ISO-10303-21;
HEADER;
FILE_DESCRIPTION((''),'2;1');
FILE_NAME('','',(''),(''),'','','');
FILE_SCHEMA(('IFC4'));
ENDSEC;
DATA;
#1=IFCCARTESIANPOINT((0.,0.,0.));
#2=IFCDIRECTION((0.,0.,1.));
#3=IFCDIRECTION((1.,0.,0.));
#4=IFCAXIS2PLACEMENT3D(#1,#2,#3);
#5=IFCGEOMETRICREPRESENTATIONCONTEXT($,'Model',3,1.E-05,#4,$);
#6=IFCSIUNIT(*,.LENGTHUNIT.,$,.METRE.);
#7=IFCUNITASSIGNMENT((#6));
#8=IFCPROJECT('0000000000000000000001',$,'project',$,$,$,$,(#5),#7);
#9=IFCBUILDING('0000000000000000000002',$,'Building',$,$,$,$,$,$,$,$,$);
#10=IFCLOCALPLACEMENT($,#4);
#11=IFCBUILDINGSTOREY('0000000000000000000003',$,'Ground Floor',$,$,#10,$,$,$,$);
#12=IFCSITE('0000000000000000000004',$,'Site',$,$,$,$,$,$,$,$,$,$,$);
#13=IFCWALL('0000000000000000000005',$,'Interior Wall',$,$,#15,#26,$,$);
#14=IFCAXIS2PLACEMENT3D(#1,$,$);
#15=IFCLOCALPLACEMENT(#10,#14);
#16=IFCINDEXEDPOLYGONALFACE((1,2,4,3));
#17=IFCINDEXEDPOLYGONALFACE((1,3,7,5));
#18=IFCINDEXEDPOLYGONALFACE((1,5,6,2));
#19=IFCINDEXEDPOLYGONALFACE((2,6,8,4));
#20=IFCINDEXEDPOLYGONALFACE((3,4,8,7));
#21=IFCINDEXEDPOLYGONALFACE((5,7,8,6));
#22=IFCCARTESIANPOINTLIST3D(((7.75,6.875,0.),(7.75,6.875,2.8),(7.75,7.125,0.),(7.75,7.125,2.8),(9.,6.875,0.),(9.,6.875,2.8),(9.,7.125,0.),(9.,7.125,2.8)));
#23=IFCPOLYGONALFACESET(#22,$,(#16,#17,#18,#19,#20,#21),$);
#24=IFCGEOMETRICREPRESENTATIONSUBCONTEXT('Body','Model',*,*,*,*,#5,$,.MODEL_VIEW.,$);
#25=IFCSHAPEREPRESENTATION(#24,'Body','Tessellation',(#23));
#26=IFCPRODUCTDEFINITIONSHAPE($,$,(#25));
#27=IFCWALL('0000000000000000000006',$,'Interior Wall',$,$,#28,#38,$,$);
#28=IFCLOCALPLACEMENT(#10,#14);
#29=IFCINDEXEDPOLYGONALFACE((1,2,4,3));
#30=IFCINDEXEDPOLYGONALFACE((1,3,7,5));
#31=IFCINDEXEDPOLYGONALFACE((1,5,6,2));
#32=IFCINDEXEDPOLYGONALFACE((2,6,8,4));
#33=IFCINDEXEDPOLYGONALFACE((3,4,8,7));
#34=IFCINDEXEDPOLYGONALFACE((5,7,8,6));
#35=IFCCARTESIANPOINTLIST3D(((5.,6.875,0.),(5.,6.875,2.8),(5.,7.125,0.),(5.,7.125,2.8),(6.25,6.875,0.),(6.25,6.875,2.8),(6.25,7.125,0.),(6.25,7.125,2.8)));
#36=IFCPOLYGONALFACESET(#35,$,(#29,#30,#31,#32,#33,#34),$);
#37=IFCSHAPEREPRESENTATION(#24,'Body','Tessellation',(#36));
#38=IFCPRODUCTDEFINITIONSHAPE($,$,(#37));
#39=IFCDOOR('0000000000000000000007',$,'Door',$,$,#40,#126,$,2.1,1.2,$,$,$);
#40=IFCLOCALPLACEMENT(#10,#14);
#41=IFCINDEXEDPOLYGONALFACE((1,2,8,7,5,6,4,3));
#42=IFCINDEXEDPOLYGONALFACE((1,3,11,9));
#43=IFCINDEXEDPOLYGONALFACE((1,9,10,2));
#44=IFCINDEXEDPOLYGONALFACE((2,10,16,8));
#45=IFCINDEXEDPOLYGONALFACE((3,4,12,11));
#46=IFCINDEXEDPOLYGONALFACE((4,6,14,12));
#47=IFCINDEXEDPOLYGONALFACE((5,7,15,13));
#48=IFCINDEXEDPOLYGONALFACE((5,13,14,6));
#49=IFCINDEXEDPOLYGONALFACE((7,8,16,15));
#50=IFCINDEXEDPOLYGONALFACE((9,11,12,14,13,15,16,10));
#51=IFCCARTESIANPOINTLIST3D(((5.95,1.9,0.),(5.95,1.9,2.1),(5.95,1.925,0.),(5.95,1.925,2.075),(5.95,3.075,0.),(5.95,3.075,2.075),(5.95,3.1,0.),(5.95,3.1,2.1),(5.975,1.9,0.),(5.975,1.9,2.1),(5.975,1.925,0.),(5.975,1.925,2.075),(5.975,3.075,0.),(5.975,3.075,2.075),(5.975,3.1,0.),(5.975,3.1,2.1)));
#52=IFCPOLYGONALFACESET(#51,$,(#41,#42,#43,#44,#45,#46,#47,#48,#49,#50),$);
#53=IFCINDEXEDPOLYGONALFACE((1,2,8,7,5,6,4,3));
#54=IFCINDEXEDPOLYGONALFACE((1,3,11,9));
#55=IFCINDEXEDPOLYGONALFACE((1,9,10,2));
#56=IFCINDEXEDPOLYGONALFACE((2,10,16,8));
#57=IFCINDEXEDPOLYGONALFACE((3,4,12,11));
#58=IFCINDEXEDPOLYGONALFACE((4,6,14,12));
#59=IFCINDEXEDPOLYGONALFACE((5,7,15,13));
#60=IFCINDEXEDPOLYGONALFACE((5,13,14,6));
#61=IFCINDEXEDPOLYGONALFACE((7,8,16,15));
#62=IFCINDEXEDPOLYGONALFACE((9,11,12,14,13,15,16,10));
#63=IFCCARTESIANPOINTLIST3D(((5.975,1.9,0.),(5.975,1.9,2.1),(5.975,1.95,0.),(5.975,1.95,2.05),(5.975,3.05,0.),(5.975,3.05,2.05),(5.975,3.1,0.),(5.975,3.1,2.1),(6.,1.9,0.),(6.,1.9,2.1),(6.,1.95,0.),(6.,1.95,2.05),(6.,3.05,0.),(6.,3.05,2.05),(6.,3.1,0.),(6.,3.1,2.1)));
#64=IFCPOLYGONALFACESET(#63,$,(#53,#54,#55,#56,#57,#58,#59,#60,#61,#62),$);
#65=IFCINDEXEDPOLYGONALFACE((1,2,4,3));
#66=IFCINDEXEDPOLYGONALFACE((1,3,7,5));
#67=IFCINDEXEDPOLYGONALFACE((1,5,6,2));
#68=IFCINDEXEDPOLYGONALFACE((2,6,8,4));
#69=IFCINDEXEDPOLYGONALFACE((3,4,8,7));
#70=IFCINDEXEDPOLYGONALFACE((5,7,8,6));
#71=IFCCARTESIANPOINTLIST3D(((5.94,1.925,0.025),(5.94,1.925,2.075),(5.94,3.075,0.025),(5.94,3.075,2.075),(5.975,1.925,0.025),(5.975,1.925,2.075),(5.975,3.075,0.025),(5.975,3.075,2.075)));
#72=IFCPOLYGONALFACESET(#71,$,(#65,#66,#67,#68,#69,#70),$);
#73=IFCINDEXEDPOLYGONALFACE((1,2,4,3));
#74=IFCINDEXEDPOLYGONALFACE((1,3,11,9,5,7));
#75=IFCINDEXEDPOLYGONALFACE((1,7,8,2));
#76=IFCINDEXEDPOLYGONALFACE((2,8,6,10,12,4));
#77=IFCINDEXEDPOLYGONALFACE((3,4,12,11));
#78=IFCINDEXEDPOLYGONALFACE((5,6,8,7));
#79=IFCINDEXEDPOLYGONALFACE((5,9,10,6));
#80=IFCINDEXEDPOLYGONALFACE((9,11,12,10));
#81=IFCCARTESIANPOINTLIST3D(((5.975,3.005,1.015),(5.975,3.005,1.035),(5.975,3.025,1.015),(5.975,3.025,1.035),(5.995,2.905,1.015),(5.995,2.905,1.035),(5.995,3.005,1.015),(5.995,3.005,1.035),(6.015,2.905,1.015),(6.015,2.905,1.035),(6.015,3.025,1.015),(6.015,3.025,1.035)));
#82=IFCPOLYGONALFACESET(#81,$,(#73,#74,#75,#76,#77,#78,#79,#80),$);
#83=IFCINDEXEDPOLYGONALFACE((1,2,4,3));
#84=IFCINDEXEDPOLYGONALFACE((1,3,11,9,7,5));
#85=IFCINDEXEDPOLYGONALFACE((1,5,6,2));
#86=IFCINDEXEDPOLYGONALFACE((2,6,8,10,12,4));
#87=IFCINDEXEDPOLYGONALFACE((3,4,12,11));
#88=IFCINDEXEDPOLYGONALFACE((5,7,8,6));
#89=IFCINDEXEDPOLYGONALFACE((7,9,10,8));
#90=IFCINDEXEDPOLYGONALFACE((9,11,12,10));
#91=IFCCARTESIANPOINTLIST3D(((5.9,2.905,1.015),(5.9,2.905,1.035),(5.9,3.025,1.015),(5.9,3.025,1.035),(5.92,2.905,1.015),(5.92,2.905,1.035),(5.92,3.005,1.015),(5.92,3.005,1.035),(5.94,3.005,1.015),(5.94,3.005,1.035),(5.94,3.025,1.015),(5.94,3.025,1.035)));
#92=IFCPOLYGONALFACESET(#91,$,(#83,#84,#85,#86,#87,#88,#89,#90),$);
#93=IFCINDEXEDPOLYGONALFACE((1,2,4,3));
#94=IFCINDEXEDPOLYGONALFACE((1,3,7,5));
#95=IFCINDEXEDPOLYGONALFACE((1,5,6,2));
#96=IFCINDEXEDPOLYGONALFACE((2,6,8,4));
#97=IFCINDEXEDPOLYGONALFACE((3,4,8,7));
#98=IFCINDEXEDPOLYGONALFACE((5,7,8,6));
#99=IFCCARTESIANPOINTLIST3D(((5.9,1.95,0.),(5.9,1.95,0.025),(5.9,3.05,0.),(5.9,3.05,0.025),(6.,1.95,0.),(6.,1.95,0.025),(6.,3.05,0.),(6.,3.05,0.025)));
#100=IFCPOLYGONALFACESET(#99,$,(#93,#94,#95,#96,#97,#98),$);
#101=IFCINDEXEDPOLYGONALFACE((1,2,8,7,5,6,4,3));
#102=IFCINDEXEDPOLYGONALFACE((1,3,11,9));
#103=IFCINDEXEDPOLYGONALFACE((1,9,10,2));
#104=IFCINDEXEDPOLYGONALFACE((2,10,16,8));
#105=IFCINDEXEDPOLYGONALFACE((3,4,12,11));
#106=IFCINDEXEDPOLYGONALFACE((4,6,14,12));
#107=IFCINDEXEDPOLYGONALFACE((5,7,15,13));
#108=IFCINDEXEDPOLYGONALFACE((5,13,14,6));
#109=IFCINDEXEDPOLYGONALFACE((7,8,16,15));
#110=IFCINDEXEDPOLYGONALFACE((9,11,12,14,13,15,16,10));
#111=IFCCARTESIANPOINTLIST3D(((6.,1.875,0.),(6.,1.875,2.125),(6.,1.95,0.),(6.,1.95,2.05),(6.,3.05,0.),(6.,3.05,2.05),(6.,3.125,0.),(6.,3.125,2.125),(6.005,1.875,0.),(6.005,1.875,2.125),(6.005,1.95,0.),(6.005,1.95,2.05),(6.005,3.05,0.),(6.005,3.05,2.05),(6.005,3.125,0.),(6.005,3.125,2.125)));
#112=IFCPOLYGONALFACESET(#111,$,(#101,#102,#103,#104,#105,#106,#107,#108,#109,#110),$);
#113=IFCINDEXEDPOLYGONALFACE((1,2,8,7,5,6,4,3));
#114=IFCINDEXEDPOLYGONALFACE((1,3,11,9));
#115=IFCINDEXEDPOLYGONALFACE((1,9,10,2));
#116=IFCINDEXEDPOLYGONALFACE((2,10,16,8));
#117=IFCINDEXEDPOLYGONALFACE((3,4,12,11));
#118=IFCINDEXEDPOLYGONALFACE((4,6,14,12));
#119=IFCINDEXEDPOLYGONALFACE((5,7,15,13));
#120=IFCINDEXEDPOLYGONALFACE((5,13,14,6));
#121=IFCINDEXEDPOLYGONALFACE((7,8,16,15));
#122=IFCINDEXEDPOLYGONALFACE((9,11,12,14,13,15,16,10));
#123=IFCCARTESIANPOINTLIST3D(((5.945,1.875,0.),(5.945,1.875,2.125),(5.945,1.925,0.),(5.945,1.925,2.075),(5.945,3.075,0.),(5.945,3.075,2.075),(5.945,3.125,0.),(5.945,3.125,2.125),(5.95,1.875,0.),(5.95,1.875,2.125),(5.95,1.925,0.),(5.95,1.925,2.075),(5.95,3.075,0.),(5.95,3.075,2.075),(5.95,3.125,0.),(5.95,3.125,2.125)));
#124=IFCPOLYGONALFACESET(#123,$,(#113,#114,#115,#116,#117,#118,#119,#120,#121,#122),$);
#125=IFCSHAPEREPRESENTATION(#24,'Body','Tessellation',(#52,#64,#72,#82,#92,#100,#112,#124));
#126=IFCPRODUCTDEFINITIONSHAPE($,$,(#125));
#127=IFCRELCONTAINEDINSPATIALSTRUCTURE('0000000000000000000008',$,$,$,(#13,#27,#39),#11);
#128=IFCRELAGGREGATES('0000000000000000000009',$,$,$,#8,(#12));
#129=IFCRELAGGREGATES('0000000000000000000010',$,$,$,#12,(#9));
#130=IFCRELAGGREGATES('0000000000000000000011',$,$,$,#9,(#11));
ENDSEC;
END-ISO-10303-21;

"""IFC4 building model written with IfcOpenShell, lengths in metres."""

from ifc_helpers import new_model, si_unit, frame, origin_with_axes, place, context, subcontext, project, spatial, line, indexed_curve, outline, extrude, element, save


model = new_model("IFC4")

# Units and contexts
model_context = context("Model", 3, precision=1e-05, world=origin_with_axes())
body_context = subcontext(model_context, "Body", "Model", "MODEL_VIEW")
ifc_project = project(units=[si_unit("LENGTHUNIT", "METRE")], contexts=[model_context])

# Site, building, storey
site = spatial("IfcSite", under=ifc_project, Name="Site")
building = spatial("IfcBuilding", under=site, Name="Building")
storey_placement = place(None, origin_with_axes())
storey = spatial("IfcBuildingStorey", under=building, at=storey_placement, Name="Ground Floor")

# Walls
for number, where, z_axis, x_axis, name in (
    (1, (9.0, 7.0, 0.0), (0.0, 0.0, 1.0), (-1.0, 0.0, 0.0), "Interior Wall"),
    (2, (6.25, 7.0, 0.0), (0.0, 0.0, 1.0), (-1.0, 0.0, 0.0), "Interior Wall"),
):
    element("IfcWall", number, at=place(storey_placement, frame(where, z_axis=z_axis, x_axis=x_axis)), inside=storey, Name=name, context=body_context, shape_type="SweptSolid", body=[
        extrude(outline(indexed_curve([(0.0, 0.0), (0.0, 0.25), (1.25, 0.25), (1.25, 0.0), (0.0, 0.0)], self_intersect=False)), frame((0.0, -0.125, 0.0), z_axis=(0.0, 0.0, 1.0), x_axis=(1.0, 0.0, 0.0)), (0.0, 0.0, 1.0), 2.8),
    ])

# Door
door_1_placement = place(storey_placement, frame((6.0, 1.9, 0.0), z_axis=(0.0, 0.0, 1.0), x_axis=(0.0, 1.0, 0.0)))
element("IfcDoor", 3, at=door_1_placement, inside=storey, Name="Door", OverallHeight=2.1, OverallWidth=1.2, context=body_context, shape_type="SweptSolid", body=[
    extrude(outline(indexed_curve([(0.0, 0.0), (0.0, 2.1), (1.2, 2.1), (1.2, 0.0), (1.175, 0.0), (1.175, 2.075), (0.025, 2.075), (0.025, 0.0)], segments=[line(1, 2, 3, 4, 5, 6, 7, 8, 1)])), frame((0.0, 0.025, 0.0), z_axis=(0.0, -1.0, 0.0), x_axis=(1.0, 0.0, 0.0)), (0.0, 0.0, -1.0), 0.025),
    extrude(outline(indexed_curve([(0.0, 0.0), (0.0, 2.1), (1.2, 2.1), (1.2, 0.0), (1.15, 0.0), (1.15, 2.05), (0.05, 2.05), (0.05, 0.0)], segments=[line(1, 2, 3, 4, 5, 6, 7, 8, 1)])), frame((0.0, 0.0, 0.0), z_axis=(0.0, -1.0, 0.0), x_axis=(1.0, 0.0, 0.0)), (0.0, 0.0, -1.0), 0.025),
    extrude(outline(indexed_curve([(0.0, 0.0), (1.15, 0.0), (1.15, 0.035), (0.0, 0.035)], segments=[line(1, 2, 3, 4, 1)])), frame((0.025, 0.025, 0.025), z_axis=(0.0, 0.0, 1.0), x_axis=(1.0, 0.0, 0.0)), (0.0, 0.0, 1.0), 2.05),
    extrude(outline(indexed_curve([(0.0, 0.0), (0.0, -0.04), (-0.12, -0.04), (-0.12, -0.02), (-0.02, -0.02), (-0.02, 0.0)], segments=[line(1, 2, 3, 4, 5, 6, 1)])), frame((1.125, 0.025, 1.015), z_axis=(0.0, 0.0, 1.0), x_axis=(1.0, 0.0, 0.0)), (0.0, 0.0, 1.0), 0.02),
    extrude(outline(indexed_curve([(0.0, 0.0), (0.0, 0.04), (-0.12, 0.04), (-0.12, 0.02), (-0.02, 0.02), (-0.02, 0.0)], segments=[line(1, 2, 3, 4, 5, 6, 1)])), frame((1.125, 0.06, 1.015), z_axis=(0.0, 0.0, 1.0), x_axis=(1.0, 0.0, 0.0)), (0.0, 0.0, 1.0), 0.02),
    extrude(outline(indexed_curve([(0.0, 0.0), (1.1, 0.0), (1.1, 0.1), (0.0, 0.1)], segments=[line(1, 2, 3, 4, 1)])), frame((0.05, 0.0, 0.0), z_axis=(0.0, 0.0, 1.0), x_axis=(1.0, 0.0, 0.0)), (0.0, 0.0, 1.0), 0.025),
    extrude(outline(indexed_curve([(0.0, 0.0), (0.0, 2.125), (1.25, 2.125), (1.25, 0.0), (1.175, 0.0), (1.175, 2.05), (0.075, 2.05), (0.075, 0.0)], segments=[line(1, 2, 3, 4, 5, 6, 7, 8, 1)])), frame((-0.025, -0.005, 0.0), z_axis=(0.0, -1.0, 0.0), x_axis=(1.0, 0.0, 0.0)), (0.0, 0.0, -1.0), 0.005),
    extrude(outline(indexed_curve([(0.0, 0.0), (0.0, 2.125), (1.25, 2.125), (1.25, 0.0), (1.2, 0.0), (1.2, 2.075), (0.05, 2.075), (0.05, 0.0)], segments=[line(1, 2, 3, 4, 5, 6, 7, 8, 1)])), frame((-0.025, 0.05, 0.0), z_axis=(0.0, -1.0, 0.0), x_axis=(1.0, 0.0, 0.0)), (0.0, 0.0, -1.0), 0.005),
])

save(model, "model.ifc")
